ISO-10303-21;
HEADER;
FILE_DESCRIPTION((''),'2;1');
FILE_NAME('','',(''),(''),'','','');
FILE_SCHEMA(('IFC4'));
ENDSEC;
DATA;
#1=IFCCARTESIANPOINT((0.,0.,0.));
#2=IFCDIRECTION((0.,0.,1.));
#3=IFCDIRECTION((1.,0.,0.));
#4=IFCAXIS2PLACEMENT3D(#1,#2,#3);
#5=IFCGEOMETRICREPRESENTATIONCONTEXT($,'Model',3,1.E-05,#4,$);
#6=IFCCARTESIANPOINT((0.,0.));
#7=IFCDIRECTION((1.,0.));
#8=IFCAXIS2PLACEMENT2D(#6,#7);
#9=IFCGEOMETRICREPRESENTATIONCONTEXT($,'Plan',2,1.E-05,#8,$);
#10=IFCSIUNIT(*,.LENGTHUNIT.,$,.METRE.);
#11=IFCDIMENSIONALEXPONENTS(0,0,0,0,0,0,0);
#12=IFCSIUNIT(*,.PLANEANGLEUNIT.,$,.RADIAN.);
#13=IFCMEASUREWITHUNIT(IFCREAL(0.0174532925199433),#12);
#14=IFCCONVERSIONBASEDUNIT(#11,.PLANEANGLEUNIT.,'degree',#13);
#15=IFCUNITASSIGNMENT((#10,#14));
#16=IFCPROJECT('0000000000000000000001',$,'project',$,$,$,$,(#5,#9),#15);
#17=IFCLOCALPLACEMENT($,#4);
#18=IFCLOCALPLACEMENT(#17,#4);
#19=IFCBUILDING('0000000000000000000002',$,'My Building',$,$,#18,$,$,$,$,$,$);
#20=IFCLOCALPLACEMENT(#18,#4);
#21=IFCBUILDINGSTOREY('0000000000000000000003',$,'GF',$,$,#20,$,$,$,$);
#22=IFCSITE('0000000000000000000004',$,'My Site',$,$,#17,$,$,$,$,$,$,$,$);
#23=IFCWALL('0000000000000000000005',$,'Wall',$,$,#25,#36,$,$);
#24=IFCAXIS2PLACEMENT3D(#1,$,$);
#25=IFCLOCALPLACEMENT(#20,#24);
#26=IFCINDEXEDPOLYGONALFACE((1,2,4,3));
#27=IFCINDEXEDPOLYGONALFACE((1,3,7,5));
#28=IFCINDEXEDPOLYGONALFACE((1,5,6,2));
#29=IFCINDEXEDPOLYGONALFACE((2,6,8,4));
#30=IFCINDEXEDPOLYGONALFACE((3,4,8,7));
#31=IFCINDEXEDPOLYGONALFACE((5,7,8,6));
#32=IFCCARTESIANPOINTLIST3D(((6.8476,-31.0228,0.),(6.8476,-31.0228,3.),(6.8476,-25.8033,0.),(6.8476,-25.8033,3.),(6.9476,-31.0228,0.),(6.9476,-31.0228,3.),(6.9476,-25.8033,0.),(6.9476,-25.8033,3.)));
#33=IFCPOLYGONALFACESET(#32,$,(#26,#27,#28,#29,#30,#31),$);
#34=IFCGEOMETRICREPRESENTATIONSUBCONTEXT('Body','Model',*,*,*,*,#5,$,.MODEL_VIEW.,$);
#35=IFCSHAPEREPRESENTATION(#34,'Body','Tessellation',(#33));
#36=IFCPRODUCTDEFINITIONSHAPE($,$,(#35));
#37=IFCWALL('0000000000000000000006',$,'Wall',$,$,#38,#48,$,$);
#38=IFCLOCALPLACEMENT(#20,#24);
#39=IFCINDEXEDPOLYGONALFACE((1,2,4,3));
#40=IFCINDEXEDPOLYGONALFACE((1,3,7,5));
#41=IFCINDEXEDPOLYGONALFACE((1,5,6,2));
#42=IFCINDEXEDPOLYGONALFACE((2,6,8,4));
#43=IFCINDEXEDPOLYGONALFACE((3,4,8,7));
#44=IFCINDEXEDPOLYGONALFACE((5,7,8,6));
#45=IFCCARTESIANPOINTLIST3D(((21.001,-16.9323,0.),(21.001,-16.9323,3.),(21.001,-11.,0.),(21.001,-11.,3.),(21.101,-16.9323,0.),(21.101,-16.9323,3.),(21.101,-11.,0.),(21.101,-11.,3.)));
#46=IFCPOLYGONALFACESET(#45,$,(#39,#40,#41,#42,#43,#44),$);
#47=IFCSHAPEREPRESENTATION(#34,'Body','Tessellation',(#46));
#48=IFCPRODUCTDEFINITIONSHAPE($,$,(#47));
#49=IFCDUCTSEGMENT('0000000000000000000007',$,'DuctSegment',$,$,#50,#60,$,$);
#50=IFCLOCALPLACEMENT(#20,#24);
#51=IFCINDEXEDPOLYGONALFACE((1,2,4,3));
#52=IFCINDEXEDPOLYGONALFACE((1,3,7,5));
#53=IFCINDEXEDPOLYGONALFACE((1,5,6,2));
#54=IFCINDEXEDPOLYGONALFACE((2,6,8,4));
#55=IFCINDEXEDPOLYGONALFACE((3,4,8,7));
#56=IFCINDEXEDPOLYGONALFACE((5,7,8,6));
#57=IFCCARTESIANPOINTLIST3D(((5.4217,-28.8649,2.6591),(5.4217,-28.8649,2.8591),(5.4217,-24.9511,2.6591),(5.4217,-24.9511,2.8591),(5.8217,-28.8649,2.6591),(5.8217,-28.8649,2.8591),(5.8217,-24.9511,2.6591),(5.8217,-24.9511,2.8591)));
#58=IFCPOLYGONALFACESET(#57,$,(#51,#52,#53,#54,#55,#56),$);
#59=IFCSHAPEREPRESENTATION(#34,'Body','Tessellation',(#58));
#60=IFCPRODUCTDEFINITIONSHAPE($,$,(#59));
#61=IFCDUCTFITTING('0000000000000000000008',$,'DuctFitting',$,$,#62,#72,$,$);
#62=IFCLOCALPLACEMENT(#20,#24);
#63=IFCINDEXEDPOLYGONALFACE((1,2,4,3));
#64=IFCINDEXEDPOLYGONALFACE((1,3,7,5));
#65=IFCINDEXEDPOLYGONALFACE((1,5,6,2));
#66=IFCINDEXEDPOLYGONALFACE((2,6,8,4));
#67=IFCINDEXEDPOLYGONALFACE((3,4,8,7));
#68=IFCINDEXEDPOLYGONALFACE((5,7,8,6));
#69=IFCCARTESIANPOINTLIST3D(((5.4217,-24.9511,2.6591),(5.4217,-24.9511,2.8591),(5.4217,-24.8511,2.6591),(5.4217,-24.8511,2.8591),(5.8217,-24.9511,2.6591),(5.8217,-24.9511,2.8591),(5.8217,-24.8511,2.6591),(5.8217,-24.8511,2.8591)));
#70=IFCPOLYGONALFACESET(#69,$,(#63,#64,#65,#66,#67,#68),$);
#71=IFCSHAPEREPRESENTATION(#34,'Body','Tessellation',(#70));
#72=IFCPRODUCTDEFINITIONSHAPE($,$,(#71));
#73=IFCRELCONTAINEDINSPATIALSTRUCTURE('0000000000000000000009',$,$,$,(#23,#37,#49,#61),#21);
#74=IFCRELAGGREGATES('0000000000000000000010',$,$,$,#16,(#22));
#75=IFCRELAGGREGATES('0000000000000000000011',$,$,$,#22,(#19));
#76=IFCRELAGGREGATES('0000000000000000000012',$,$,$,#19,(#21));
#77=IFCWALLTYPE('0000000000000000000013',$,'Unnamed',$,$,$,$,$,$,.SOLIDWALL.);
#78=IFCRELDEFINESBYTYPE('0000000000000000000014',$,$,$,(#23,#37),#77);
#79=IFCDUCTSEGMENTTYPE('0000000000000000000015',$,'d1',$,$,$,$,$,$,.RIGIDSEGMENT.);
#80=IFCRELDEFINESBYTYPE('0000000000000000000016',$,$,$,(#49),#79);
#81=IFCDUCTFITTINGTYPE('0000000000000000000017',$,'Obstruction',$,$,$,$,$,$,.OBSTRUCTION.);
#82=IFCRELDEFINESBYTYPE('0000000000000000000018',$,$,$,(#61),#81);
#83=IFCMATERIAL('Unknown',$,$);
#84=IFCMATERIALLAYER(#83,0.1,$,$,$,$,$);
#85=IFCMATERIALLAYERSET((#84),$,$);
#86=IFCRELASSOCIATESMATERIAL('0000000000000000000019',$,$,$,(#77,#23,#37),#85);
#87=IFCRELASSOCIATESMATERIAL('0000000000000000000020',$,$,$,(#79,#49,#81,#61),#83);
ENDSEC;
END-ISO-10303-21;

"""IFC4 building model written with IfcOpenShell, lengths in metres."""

from ifc_helpers import new_model, entity, si_unit, converted_unit, frame, origin_with_axes, origin_2d_with_axis, place, context, subcontext, project, spatial, line, indexed_curve, rectangle, outline, extrude, material, layer, layer_set, layer_usage, material_profile, profile_set, profile_usage, type_object, element, save


model = new_model("IFC4")

# Units and contexts
model_context = context("Model", 3, precision=1e-05, world=origin_with_axes())
plan_context = context("Plan", 2, precision=1e-05, world=origin_2d_with_axis())
body_context_1 = subcontext(model_context, "Body", "Model", "MODEL_VIEW")
ifc_project = project(units=[si_unit("LENGTHUNIT", "METRE"), converted_unit("PLANEANGLEUNIT", "degree", entity("IfcReal", 0.0174532925199433), si_unit("PLANEANGLEUNIT", "RADIAN"), dimensions=[0, 0, 0, 0, 0, 0, 0])], contexts=[model_context, plan_context])

# Site, building, storey
site_placement = place(None, origin_with_axes())
site = spatial("IfcSite", under=ifc_project, at=site_placement, Name="My Site")
building_placement = place(site_placement, origin_with_axes())
building = spatial("IfcBuilding", under=site, at=building_placement, Name="My Building")
storey_placement = place(building_placement, origin_with_axes())
storey = spatial("IfcBuildingStorey", under=building, at=storey_placement, Name="GF")

# Shared definitions
ifc_material = material(Name="Unknown")
ifc_layer = layer(ifc_material, 0.1)
ifc_layer_set = layer_set([ifc_layer])
wall_type = type_object("IfcWallType", Name="Unnamed", PredefinedType="SOLIDWALL", material=ifc_layer_set)

# Walls
ifc_layer_usage_1 = layer_usage(ifc_layer_set, "AXIS2", "POSITIVE", 0.0)
wall_1_placement = place(storey_placement, frame((6.8476, -25.8033, 0.0), z_axis=(0.0, 0.0, 1.0), x_axis=(0.0, -1.0, 0.0)))
element("IfcWall", 1, at=wall_1_placement, inside=storey, type_object=wall_type, material=ifc_layer_usage_1, Name="Wall", context=body_context_1, shape_type="SweptSolid", body=[
    extrude(outline(indexed_curve([(0.0, 0.0), (0.0, 0.1), (5.2195, 0.1), (5.2195, 0.0)], segments=[line(1, 2, 3, 4, 1)])), origin_with_axes(), (0.0, 0.0, 1.0), 3.0),
])
ifc_layer_usage_2 = layer_usage(ifc_layer_set, "AXIS2", "POSITIVE", 0.0)
wall_2_placement = place(storey_placement, frame((21.101, -16.9323, 0.0), z_axis=(0.0, 0.0, 1.0), x_axis=(0.0, 1.0, 0.0)))
element("IfcWall", 2, at=wall_2_placement, inside=storey, type_object=wall_type, material=ifc_layer_usage_2, Name="Wall", context=body_context_1, shape_type="SweptSolid", body=[
    extrude(outline(indexed_curve([(0.0, 0.0), (0.0, 0.1), (5.9323, 0.1), (5.9323, 0.0)], segments=[line(1, 2, 3, 4, 1)])), origin_with_axes(), (0.0, 0.0, 1.0), 3.0),
])

# Duct segment
ifc_material_profile_1 = material_profile(ifc_material, rectangle(XDim=0.4, YDim=0.2))
ifc_profile_set_1 = profile_set([ifc_material_profile_1])
ifc_profile_usage_1 = profile_usage(ifc_profile_set_1, cardinal=5)
duct_segment_type = type_object("IfcDuctSegmentType", Name="d1", PredefinedType="RIGIDSEGMENT", material=ifc_profile_set_1)
duct_segment_placement = place(storey_placement, frame((5.6217, -24.9511, 2.7591), z_axis=(0.0, -1.0, 0.0), x_axis=(1.0, 0.0, 0.0)))
element("IfcDuctSegment", 3, at=duct_segment_placement, inside=storey, type_object=duct_segment_type, material=ifc_profile_usage_1, Name="DuctSegment", context=body_context_1, shape_type="SweptSolid", body=[
    extrude(rectangle(XDim=0.4, YDim=0.2), origin_with_axes(), (0.0, 0.0, 1.0), 3.9138),
])

# Duct fitting
ifc_material_profile_2 = material_profile(ifc_material, rectangle(XDim=0.4, YDim=0.2))
ifc_profile_set_2 = profile_set([ifc_material_profile_2])
ifc_profile_usage_2 = profile_usage(ifc_profile_set_2, cardinal=5)
duct_fitting_type = type_object("IfcDuctFittingType", Name="Obstruction", PredefinedType="OBSTRUCTION", material=ifc_profile_set_2)
duct_fitting_placement = place(storey_placement, frame((5.6217, -24.8511, 2.7591), z_axis=(0.0, -1.0, 0.0), x_axis=(1.0, 0.0, 0.0)))
element("IfcDuctFitting", 4, at=duct_fitting_placement, inside=storey, type_object=duct_fitting_type, material=ifc_profile_usage_2, Name="DuctFitting", context=body_context_1, shape_type="SweptSolid", body=[
    extrude(rectangle(XDim=0.4, YDim=0.2), origin_with_axes(), (0.0, 0.0, 1.0), 0.1),
])

save(model, "model.ifc")
